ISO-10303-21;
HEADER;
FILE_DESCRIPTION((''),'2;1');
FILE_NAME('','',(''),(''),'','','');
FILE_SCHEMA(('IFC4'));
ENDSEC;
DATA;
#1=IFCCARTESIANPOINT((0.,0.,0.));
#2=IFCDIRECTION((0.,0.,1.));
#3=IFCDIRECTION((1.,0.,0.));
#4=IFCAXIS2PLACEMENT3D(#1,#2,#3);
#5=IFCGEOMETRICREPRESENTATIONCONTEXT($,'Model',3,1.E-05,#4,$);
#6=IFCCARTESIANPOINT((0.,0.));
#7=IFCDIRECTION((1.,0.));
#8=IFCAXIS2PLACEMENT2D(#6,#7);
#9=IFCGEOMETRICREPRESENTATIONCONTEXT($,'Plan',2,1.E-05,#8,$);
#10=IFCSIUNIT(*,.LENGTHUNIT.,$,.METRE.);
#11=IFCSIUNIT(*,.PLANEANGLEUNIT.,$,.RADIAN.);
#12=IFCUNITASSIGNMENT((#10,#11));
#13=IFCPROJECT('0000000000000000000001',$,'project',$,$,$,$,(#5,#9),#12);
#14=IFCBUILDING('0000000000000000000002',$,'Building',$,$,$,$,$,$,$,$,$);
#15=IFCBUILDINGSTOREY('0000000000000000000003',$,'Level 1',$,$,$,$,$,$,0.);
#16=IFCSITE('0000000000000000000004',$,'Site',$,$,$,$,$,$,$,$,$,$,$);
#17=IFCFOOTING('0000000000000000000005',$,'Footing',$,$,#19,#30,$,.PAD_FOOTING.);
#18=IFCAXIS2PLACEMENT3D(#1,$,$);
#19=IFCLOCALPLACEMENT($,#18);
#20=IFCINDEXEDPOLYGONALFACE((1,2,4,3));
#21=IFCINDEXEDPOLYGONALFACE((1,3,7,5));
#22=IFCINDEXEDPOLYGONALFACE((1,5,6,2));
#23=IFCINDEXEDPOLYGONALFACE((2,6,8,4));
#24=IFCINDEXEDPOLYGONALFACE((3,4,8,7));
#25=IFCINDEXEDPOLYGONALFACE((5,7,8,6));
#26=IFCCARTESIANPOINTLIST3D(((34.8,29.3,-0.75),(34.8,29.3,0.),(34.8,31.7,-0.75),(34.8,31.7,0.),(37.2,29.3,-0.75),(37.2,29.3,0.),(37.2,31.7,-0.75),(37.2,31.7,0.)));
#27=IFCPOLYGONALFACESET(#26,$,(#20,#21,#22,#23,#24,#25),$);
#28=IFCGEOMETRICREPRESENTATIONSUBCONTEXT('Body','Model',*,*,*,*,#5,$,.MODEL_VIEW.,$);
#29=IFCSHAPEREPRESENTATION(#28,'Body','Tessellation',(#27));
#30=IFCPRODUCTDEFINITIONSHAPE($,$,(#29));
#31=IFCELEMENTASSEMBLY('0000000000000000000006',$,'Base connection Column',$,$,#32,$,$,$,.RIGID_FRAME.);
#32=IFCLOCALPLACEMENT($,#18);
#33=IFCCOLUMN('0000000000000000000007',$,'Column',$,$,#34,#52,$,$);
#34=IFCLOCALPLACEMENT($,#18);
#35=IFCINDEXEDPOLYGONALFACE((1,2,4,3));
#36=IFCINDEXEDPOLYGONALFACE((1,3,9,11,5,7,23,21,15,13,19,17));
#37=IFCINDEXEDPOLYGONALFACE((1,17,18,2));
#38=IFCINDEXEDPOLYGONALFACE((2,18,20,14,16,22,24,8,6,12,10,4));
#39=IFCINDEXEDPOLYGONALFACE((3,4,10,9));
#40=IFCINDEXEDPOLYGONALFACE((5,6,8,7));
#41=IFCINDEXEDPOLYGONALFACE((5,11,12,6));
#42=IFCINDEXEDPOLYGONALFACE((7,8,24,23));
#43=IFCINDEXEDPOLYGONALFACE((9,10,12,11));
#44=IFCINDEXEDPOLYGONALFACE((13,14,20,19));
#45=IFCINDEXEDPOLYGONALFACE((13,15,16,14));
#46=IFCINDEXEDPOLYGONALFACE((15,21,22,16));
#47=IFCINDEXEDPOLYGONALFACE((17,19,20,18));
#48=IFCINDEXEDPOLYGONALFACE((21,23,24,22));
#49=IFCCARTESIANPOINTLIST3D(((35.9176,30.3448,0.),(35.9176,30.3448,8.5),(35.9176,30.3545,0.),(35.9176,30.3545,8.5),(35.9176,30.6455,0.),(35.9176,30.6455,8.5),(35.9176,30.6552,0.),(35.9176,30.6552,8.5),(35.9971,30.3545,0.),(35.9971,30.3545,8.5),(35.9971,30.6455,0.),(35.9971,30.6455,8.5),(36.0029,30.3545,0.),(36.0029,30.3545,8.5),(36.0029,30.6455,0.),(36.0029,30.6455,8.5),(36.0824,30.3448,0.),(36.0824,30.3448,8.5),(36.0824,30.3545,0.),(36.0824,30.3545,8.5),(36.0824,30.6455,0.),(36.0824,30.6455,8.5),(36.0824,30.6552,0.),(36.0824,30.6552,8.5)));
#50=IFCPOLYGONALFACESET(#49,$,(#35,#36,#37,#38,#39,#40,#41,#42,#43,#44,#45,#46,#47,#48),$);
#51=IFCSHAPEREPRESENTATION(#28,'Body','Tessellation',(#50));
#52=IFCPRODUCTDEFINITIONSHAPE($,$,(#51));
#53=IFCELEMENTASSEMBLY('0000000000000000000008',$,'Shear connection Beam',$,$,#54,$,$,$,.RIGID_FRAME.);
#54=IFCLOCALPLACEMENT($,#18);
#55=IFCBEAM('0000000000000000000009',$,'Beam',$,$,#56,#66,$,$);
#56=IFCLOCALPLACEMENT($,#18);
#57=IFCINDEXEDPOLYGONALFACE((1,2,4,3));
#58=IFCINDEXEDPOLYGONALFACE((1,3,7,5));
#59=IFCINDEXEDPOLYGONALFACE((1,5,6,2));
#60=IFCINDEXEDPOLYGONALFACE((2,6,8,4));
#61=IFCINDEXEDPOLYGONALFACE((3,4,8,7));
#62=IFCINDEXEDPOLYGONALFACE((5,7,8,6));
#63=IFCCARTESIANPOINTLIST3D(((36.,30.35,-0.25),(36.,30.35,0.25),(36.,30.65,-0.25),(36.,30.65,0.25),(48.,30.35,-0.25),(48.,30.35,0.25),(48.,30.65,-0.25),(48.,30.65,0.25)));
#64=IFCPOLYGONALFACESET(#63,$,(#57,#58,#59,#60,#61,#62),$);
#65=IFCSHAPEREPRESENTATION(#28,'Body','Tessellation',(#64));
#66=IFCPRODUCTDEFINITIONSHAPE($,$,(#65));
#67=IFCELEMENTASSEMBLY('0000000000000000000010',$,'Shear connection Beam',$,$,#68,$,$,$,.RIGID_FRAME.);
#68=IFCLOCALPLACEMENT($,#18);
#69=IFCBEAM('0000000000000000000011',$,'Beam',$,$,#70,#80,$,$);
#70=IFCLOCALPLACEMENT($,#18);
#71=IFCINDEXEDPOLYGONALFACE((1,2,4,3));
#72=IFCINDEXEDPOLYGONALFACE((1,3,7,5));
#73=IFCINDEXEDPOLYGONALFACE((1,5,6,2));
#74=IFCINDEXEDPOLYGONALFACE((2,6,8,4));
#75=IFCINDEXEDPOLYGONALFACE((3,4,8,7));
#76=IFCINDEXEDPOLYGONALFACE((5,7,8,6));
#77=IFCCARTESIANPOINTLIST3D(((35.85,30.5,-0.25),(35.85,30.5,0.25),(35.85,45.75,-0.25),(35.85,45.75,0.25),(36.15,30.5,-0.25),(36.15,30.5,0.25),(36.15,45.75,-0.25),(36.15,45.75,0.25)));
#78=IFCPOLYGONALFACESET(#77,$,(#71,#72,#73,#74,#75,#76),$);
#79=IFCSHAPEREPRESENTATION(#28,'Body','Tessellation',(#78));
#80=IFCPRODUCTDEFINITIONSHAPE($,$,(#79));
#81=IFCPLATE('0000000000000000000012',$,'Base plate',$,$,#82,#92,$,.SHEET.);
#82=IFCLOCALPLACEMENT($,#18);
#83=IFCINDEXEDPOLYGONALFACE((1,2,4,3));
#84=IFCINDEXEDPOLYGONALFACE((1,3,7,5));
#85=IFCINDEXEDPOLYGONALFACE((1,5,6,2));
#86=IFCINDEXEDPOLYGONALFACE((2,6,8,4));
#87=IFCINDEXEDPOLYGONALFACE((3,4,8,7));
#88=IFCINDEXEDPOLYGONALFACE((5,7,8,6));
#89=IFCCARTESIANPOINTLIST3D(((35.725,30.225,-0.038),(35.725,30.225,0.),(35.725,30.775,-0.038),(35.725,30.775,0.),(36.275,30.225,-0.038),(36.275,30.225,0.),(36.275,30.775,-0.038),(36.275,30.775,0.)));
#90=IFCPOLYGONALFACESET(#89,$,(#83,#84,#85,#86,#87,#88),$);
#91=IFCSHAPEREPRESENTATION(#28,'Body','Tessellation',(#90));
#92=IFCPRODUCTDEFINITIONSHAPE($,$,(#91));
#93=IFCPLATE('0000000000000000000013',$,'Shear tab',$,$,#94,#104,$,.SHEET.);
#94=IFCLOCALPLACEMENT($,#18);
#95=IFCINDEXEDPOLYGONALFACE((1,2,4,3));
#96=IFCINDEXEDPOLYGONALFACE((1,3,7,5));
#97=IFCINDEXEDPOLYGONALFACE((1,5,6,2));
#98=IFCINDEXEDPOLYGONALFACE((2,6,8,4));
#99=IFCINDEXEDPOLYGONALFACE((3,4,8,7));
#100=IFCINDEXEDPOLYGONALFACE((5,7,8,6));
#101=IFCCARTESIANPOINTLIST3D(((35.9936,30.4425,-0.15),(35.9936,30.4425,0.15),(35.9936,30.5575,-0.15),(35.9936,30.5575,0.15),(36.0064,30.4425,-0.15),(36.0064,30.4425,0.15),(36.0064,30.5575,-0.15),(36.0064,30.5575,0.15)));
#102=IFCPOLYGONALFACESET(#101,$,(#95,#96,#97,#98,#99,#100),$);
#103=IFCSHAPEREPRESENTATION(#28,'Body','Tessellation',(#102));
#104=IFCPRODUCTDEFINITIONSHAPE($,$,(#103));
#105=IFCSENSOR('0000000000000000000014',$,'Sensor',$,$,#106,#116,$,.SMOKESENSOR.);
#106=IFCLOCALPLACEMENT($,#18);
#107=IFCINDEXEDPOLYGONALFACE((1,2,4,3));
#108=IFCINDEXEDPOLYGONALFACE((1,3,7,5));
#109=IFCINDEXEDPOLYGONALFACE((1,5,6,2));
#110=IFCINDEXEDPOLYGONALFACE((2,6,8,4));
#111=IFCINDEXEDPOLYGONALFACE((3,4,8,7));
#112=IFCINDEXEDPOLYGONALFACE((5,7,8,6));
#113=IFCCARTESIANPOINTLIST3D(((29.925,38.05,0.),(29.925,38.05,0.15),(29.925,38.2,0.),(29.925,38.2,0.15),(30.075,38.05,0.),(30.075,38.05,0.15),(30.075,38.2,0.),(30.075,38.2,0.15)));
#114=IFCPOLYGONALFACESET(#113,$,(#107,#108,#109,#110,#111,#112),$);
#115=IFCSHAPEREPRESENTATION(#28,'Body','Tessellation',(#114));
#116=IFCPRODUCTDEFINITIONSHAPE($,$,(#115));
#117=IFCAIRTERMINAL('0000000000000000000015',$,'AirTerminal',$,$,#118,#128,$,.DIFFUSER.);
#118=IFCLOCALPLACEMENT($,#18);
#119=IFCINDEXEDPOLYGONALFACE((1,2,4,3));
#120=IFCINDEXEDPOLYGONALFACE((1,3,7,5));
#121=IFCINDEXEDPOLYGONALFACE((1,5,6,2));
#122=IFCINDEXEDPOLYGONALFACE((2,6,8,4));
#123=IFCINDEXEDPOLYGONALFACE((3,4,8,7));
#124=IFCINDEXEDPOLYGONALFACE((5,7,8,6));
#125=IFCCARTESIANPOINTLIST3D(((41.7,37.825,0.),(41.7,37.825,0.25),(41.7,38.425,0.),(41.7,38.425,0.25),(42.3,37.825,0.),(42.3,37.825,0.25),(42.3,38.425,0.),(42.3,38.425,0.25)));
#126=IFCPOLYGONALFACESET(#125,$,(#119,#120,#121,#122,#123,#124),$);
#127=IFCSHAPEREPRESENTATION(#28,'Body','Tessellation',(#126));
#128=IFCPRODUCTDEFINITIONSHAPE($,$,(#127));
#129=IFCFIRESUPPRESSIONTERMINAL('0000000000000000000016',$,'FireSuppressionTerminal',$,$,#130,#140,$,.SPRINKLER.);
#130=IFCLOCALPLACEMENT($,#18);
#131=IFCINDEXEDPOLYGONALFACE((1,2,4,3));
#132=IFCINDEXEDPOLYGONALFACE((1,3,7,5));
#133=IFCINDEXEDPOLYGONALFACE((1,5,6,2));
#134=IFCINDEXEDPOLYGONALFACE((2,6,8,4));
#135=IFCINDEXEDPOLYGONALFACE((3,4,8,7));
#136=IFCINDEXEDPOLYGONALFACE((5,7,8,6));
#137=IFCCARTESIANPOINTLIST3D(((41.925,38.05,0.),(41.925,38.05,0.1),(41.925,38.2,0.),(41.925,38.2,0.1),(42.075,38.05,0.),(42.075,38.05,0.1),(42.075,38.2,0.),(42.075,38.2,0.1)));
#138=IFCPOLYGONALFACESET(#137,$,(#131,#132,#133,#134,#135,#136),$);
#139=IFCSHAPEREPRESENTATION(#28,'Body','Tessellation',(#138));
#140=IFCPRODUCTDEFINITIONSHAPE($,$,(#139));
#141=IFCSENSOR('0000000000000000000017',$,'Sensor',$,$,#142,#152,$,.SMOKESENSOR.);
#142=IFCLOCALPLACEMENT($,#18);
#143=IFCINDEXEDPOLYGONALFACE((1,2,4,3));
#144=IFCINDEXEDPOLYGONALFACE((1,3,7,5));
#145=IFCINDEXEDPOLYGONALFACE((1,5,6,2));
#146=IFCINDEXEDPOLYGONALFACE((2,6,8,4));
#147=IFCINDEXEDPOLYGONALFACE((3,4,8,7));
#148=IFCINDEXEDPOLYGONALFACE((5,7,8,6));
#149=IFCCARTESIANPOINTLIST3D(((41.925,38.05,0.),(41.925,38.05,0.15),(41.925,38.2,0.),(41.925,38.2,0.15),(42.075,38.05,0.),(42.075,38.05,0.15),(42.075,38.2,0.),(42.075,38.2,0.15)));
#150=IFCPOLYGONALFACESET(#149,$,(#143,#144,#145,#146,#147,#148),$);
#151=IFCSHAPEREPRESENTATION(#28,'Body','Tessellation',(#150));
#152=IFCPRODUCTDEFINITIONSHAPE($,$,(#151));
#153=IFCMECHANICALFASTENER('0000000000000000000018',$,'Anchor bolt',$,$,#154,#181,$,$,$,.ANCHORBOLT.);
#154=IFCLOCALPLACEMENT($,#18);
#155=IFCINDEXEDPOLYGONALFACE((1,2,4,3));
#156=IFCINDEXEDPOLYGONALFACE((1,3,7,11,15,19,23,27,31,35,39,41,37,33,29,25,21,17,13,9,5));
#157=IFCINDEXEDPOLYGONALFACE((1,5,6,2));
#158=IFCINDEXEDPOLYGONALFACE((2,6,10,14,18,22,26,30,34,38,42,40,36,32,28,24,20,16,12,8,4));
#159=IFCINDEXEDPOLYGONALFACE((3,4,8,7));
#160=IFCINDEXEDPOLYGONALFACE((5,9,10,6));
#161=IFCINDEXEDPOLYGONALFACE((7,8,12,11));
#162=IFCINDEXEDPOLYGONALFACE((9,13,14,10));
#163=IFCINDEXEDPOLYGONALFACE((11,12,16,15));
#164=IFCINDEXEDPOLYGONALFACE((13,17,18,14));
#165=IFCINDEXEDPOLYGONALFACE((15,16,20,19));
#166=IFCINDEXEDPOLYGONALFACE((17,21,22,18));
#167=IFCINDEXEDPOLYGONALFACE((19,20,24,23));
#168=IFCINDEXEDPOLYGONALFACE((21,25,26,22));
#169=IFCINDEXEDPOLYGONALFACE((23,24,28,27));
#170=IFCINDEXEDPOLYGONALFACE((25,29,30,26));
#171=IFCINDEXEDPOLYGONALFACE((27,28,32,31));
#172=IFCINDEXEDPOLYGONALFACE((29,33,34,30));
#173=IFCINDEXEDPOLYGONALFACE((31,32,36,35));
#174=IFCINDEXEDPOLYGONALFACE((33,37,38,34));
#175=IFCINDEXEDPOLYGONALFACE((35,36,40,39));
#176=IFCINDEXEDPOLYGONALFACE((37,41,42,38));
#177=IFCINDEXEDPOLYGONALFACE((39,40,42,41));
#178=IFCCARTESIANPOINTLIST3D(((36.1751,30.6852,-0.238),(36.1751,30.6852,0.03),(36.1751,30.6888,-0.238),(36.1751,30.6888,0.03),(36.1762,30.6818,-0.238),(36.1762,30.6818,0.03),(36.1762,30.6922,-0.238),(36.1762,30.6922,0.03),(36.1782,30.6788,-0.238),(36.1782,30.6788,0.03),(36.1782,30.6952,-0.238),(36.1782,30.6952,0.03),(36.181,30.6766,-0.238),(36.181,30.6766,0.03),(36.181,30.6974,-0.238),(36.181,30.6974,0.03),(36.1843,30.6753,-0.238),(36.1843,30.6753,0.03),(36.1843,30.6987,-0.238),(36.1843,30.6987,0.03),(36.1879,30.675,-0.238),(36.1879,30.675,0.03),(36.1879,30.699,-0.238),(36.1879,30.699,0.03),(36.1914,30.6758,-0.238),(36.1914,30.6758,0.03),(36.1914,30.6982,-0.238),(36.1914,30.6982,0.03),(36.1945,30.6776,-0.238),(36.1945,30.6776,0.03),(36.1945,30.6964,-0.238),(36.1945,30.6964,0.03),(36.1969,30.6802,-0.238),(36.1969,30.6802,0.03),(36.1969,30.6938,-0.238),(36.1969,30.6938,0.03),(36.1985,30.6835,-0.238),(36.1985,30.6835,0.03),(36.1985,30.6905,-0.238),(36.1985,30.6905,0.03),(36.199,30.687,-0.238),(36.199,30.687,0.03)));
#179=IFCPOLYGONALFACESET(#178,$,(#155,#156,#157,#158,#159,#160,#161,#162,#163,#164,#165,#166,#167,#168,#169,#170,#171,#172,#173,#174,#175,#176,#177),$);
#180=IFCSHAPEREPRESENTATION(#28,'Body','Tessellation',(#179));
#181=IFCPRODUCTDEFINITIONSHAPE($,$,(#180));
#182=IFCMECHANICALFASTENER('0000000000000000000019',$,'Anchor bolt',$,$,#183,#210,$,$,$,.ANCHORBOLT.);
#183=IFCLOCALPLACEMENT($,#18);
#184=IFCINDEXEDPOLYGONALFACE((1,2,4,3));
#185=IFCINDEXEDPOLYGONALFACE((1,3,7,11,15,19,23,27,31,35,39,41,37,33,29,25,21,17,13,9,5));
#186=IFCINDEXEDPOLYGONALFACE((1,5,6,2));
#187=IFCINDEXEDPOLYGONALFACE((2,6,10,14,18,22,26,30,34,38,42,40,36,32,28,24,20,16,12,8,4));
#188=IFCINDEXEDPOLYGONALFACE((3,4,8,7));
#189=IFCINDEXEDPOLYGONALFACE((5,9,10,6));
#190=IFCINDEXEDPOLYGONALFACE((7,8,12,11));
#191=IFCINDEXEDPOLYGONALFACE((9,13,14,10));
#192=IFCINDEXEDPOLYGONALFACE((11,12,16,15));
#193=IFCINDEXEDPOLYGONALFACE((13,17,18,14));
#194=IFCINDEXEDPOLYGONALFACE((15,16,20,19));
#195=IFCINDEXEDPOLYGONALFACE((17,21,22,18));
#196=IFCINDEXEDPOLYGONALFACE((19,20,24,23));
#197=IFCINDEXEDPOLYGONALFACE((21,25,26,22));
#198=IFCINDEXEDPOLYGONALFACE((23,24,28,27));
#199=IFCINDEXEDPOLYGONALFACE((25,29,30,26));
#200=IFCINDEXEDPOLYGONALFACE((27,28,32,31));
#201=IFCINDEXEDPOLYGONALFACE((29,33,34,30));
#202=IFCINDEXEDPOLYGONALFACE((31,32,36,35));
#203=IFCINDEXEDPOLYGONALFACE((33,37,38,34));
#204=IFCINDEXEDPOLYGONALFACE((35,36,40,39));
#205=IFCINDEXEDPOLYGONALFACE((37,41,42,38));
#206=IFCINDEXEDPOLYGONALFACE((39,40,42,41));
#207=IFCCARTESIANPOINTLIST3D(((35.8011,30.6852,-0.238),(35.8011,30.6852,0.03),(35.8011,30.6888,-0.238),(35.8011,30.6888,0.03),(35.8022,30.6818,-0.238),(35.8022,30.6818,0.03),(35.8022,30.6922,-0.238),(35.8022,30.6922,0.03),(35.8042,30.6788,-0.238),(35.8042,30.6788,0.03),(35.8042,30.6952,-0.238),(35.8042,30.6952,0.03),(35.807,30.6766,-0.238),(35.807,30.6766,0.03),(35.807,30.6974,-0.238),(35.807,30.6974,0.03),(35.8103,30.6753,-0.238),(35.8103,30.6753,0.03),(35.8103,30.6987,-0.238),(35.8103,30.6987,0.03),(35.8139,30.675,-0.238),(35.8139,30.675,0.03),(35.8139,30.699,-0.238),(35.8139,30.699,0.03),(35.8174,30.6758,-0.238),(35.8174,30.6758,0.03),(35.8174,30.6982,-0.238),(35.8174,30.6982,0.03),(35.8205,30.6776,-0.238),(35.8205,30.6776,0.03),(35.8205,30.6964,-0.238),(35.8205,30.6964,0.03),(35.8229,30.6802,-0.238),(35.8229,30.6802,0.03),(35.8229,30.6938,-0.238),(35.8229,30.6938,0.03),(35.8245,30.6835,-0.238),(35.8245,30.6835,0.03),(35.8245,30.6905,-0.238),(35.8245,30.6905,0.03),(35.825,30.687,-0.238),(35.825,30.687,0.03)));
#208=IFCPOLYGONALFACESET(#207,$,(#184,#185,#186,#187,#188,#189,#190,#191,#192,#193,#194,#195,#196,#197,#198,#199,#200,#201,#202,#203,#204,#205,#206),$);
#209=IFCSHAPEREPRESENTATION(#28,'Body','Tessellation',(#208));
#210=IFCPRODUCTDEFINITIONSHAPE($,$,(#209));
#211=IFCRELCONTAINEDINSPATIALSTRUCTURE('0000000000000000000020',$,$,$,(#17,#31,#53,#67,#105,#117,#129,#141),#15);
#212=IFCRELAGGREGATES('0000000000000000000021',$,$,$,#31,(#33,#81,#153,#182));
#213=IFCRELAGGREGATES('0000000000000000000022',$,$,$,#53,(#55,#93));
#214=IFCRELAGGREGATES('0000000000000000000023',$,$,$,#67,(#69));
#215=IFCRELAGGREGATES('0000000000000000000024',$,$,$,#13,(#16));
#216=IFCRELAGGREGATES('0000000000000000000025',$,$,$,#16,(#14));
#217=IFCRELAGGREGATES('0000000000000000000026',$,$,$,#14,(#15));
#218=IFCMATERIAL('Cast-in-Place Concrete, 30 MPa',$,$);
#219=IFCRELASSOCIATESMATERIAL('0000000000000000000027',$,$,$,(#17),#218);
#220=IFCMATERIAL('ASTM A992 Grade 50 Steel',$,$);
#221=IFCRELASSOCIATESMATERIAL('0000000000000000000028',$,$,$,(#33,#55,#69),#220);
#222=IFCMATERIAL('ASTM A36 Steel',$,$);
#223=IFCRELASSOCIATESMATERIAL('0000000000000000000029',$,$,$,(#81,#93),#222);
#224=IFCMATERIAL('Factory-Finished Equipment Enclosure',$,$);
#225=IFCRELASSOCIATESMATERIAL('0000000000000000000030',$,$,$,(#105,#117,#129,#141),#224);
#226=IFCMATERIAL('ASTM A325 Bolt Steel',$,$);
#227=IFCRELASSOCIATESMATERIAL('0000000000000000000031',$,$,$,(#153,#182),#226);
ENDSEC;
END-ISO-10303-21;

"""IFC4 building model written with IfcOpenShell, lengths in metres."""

from ifc_helpers import new_model, si_unit, frame, origin_with_axes, origin_2d, origin_2d_with_axis, place, context, subcontext, project, spatial, rectangle, circle, i_section, extrude, material, element, aggregate, save


model = new_model("IFC4")

# Units and contexts
model_context = context("Model", 3, precision=1e-05, world=origin_with_axes())
plan_context = context("Plan", 2, precision=1e-05, world=origin_2d_with_axis())
body_context = subcontext(model_context, "Body", "Model", "MODEL_VIEW")
ifc_project = project(units=[si_unit("LENGTHUNIT", "METRE"), si_unit("PLANEANGLEUNIT", "RADIAN")], contexts=[model_context, plan_context])

# Site, building, storey
site = spatial("IfcSite", under=ifc_project, Name="Site")
building = spatial("IfcBuilding", under=site, Name="Building")
storey = spatial("IfcBuildingStorey", under=building, Name="Level 1", Elevation=0.0)

# Footing
ifc_material_1 = material(Name="Cast-in-Place Concrete, 30 MPa")
footing_placement = place(None, frame((36.0, 30.5, -0.75), z_axis=(0.0, 0.0, 1.0), x_axis=(1.0, 0.0, 0.0)))
element("IfcFooting", 1, at=footing_placement, inside=storey, material=ifc_material_1, Name="Footing", PredefinedType="PAD_FOOTING", context=body_context, shape_type="SweptSolid", body=[
    extrude(rectangle(XDim=2.4, YDim=2.4, at=origin_2d_with_axis()), origin_with_axes(), (0.0, 0.0, 1.0), 0.75),
])

# Element assembly, column
assembly_1 = element("IfcElementAssembly", 2, inside=storey, Name="Base connection Column", PredefinedType="RIGID_FRAME")
ifc_material_2 = material(Name="ASTM A992 Grade 50 Steel")
column_placement = place(None, frame((36.0, 30.5, 0.0), z_axis=(0.0, 0.0, 1.0), x_axis=(1.0, 0.0, 0.0)))
column = element("IfcColumn", 3, at=column_placement, material=ifc_material_2, Name="Column", context=body_context, shape_type="SweptSolid", body=[
    extrude(i_section(OverallWidth=0.1648, OverallDepth=0.3104, WebThickness=0.0058, FlangeThickness=0.0097, at=origin_2d_with_axis()), origin_with_axes(), (0.0, 0.0, 1.0), 8.5),
])

# Element assemblies, beams
assembly_2 = element("IfcElementAssembly", 4, inside=storey, Name="Shear connection Beam", PredefinedType="RIGID_FRAME")
beam_1_placement = place(None, frame((36.0, 30.5, 0.0), z_axis=(1.0, 0.0, 0.0), x_axis=(0.0, 1.0, 0.0)))
beam_1 = element("IfcBeam", 5, at=beam_1_placement, material=ifc_material_2, Name="Beam", context=body_context, shape_type="SweptSolid", body=[
    extrude(rectangle(XDim=0.3, YDim=0.5, at=origin_2d_with_axis()), origin_with_axes(), (0.0, 0.0, 1.0), 12.0),
])
assembly_3 = element("IfcElementAssembly", 6, inside=storey, Name="Shear connection Beam", PredefinedType="RIGID_FRAME")
beam_2_placement = place(None, frame((36.0, 30.5, 0.0), z_axis=(0.0, 1.0, 0.0), x_axis=(-1.0, 0.0, 0.0)))
beam_2 = element("IfcBeam", 7, at=beam_2_placement, material=ifc_material_2, Name="Beam", context=body_context, shape_type="SweptSolid", body=[
    extrude(rectangle(XDim=0.3, YDim=0.5, at=origin_2d_with_axis()), origin_with_axes(), (0.0, 0.0, 1.0), 15.25),
])

# Plates
ifc_material_3 = material(Name="ASTM A36 Steel")
plate_1_placement = place(None, frame((36.0, 30.5, -0.038), z_axis=(0.0, 0.0, 1.0), x_axis=(1.0, 0.0, 0.0)))
plate_1 = element("IfcPlate", 8, at=plate_1_placement, material=ifc_material_3, Name="Base plate", PredefinedType="SHEET", context=body_context, shape_type="SweptSolid", body=[
    extrude(rectangle(XDim=0.55, YDim=0.55, at=origin_2d_with_axis()), origin_with_axes(), (0.0, 0.0, 1.0), 0.038),
])
plate_2_placement = place(None, frame((36.0, 30.5, -0.15), z_axis=(0.0, 0.0, 1.0), x_axis=(1.0, 0.0, 0.0)))
plate_2 = element("IfcPlate", 9, at=plate_2_placement, material=ifc_material_3, Name="Shear tab", PredefinedType="SHEET", context=body_context, shape_type="SweptSolid", body=[
    extrude(rectangle(XDim=0.0127, YDim=0.115, at=origin_2d_with_axis()), origin_with_axes(), (0.0, 0.0, 1.0), 0.3),
])

# Sensor
ifc_material_4 = material(Name="Factory-Finished Equipment Enclosure")
sensor_1_placement = place(None, frame((30.0, 38.125, 0.0), z_axis=(0.0, 0.0, 1.0), x_axis=(1.0, 0.0, 0.0)))
element("IfcSensor", 10, at=sensor_1_placement, inside=storey, material=ifc_material_4, Name="Sensor", PredefinedType="SMOKESENSOR", context=body_context, shape_type="SweptSolid", body=[
    extrude(rectangle(XDim=0.15, YDim=0.15, at=origin_2d_with_axis()), origin_with_axes(), (0.0, 0.0, 1.0), 0.15),
])

# Air terminal
air_terminal_placement = place(None, frame((42.0, 38.125, 0.0), z_axis=(0.0, 0.0, 1.0), x_axis=(1.0, 0.0, 0.0)))
element("IfcAirTerminal", 11, at=air_terminal_placement, inside=storey, material=ifc_material_4, Name="AirTerminal", PredefinedType="DIFFUSER", context=body_context, shape_type="SweptSolid", body=[
    extrude(rectangle(XDim=0.6, YDim=0.6, at=origin_2d_with_axis()), origin_with_axes(), (0.0, 0.0, 1.0), 0.25),
])

# Fire suppression terminal
fire_suppression_terminal_placement = place(None, frame((42.0, 38.125, 0.0), z_axis=(0.0, 0.0, 1.0), x_axis=(1.0, 0.0, 0.0)))
element("IfcFireSuppressionTerminal", 12, at=fire_suppression_terminal_placement, inside=storey, material=ifc_material_4, Name="FireSuppressionTerminal", PredefinedType="SPRINKLER", context=body_context, shape_type="SweptSolid", body=[
    extrude(rectangle(XDim=0.15, YDim=0.15, at=origin_2d_with_axis()), origin_with_axes(), (0.0, 0.0, 1.0), 0.1),
])

# Sensor
sensor_2_placement = place(None, frame((42.0, 38.125, 0.0), z_axis=(0.0, 0.0, 1.0), x_axis=(1.0, 0.0, 0.0)))
element("IfcSensor", 13, at=sensor_2_placement, inside=storey, material=ifc_material_4, Name="Sensor", PredefinedType="SMOKESENSOR", context=body_context, shape_type="SweptSolid", body=[
    extrude(rectangle(XDim=0.15, YDim=0.15, at=origin_2d_with_axis()), origin_with_axes(), (0.0, 0.0, 1.0), 0.15),
])

# Mechanical fasteners
ifc_material_5 = material(Name="ASTM A325 Bolt Steel")
mechanical_fastener_1_placement = place(None, frame((36.187, 30.687, -0.238), z_axis=(0.0, 0.0, 1.0), x_axis=(1.0, 0.0, 0.0)))
mechanical_fastener_1 = element("IfcMechanicalFastener", 14, at=mechanical_fastener_1_placement, material=ifc_material_5, Name="Anchor bolt", PredefinedType="ANCHORBOLT", context=body_context, shape_type="SweptSolid", body=[
    extrude(circle(Radius=0.012, at=origin_2d()), origin_with_axes(), (0.0, 0.0, 1.0), 0.268),
])
mechanical_fastener_2_placement = place(None, frame((35.813, 30.687, -0.238), z_axis=(0.0, 0.0, 1.0), x_axis=(1.0, 0.0, 0.0)))
mechanical_fastener_2 = element("IfcMechanicalFastener", 15, at=mechanical_fastener_2_placement, material=ifc_material_5, Name="Anchor bolt", PredefinedType="ANCHORBOLT", context=body_context, shape_type="SweptSolid", body=[
    extrude(circle(Radius=0.012, at=origin_2d()), origin_with_axes(), (0.0, 0.0, 1.0), 0.268),
])
aggregate(assembly_1, [column, plate_1, mechanical_fastener_1, mechanical_fastener_2])

aggregate(assembly_2, [beam_1, plate_2])

aggregate(assembly_3, [beam_2])

save(model, "model.ifc")
